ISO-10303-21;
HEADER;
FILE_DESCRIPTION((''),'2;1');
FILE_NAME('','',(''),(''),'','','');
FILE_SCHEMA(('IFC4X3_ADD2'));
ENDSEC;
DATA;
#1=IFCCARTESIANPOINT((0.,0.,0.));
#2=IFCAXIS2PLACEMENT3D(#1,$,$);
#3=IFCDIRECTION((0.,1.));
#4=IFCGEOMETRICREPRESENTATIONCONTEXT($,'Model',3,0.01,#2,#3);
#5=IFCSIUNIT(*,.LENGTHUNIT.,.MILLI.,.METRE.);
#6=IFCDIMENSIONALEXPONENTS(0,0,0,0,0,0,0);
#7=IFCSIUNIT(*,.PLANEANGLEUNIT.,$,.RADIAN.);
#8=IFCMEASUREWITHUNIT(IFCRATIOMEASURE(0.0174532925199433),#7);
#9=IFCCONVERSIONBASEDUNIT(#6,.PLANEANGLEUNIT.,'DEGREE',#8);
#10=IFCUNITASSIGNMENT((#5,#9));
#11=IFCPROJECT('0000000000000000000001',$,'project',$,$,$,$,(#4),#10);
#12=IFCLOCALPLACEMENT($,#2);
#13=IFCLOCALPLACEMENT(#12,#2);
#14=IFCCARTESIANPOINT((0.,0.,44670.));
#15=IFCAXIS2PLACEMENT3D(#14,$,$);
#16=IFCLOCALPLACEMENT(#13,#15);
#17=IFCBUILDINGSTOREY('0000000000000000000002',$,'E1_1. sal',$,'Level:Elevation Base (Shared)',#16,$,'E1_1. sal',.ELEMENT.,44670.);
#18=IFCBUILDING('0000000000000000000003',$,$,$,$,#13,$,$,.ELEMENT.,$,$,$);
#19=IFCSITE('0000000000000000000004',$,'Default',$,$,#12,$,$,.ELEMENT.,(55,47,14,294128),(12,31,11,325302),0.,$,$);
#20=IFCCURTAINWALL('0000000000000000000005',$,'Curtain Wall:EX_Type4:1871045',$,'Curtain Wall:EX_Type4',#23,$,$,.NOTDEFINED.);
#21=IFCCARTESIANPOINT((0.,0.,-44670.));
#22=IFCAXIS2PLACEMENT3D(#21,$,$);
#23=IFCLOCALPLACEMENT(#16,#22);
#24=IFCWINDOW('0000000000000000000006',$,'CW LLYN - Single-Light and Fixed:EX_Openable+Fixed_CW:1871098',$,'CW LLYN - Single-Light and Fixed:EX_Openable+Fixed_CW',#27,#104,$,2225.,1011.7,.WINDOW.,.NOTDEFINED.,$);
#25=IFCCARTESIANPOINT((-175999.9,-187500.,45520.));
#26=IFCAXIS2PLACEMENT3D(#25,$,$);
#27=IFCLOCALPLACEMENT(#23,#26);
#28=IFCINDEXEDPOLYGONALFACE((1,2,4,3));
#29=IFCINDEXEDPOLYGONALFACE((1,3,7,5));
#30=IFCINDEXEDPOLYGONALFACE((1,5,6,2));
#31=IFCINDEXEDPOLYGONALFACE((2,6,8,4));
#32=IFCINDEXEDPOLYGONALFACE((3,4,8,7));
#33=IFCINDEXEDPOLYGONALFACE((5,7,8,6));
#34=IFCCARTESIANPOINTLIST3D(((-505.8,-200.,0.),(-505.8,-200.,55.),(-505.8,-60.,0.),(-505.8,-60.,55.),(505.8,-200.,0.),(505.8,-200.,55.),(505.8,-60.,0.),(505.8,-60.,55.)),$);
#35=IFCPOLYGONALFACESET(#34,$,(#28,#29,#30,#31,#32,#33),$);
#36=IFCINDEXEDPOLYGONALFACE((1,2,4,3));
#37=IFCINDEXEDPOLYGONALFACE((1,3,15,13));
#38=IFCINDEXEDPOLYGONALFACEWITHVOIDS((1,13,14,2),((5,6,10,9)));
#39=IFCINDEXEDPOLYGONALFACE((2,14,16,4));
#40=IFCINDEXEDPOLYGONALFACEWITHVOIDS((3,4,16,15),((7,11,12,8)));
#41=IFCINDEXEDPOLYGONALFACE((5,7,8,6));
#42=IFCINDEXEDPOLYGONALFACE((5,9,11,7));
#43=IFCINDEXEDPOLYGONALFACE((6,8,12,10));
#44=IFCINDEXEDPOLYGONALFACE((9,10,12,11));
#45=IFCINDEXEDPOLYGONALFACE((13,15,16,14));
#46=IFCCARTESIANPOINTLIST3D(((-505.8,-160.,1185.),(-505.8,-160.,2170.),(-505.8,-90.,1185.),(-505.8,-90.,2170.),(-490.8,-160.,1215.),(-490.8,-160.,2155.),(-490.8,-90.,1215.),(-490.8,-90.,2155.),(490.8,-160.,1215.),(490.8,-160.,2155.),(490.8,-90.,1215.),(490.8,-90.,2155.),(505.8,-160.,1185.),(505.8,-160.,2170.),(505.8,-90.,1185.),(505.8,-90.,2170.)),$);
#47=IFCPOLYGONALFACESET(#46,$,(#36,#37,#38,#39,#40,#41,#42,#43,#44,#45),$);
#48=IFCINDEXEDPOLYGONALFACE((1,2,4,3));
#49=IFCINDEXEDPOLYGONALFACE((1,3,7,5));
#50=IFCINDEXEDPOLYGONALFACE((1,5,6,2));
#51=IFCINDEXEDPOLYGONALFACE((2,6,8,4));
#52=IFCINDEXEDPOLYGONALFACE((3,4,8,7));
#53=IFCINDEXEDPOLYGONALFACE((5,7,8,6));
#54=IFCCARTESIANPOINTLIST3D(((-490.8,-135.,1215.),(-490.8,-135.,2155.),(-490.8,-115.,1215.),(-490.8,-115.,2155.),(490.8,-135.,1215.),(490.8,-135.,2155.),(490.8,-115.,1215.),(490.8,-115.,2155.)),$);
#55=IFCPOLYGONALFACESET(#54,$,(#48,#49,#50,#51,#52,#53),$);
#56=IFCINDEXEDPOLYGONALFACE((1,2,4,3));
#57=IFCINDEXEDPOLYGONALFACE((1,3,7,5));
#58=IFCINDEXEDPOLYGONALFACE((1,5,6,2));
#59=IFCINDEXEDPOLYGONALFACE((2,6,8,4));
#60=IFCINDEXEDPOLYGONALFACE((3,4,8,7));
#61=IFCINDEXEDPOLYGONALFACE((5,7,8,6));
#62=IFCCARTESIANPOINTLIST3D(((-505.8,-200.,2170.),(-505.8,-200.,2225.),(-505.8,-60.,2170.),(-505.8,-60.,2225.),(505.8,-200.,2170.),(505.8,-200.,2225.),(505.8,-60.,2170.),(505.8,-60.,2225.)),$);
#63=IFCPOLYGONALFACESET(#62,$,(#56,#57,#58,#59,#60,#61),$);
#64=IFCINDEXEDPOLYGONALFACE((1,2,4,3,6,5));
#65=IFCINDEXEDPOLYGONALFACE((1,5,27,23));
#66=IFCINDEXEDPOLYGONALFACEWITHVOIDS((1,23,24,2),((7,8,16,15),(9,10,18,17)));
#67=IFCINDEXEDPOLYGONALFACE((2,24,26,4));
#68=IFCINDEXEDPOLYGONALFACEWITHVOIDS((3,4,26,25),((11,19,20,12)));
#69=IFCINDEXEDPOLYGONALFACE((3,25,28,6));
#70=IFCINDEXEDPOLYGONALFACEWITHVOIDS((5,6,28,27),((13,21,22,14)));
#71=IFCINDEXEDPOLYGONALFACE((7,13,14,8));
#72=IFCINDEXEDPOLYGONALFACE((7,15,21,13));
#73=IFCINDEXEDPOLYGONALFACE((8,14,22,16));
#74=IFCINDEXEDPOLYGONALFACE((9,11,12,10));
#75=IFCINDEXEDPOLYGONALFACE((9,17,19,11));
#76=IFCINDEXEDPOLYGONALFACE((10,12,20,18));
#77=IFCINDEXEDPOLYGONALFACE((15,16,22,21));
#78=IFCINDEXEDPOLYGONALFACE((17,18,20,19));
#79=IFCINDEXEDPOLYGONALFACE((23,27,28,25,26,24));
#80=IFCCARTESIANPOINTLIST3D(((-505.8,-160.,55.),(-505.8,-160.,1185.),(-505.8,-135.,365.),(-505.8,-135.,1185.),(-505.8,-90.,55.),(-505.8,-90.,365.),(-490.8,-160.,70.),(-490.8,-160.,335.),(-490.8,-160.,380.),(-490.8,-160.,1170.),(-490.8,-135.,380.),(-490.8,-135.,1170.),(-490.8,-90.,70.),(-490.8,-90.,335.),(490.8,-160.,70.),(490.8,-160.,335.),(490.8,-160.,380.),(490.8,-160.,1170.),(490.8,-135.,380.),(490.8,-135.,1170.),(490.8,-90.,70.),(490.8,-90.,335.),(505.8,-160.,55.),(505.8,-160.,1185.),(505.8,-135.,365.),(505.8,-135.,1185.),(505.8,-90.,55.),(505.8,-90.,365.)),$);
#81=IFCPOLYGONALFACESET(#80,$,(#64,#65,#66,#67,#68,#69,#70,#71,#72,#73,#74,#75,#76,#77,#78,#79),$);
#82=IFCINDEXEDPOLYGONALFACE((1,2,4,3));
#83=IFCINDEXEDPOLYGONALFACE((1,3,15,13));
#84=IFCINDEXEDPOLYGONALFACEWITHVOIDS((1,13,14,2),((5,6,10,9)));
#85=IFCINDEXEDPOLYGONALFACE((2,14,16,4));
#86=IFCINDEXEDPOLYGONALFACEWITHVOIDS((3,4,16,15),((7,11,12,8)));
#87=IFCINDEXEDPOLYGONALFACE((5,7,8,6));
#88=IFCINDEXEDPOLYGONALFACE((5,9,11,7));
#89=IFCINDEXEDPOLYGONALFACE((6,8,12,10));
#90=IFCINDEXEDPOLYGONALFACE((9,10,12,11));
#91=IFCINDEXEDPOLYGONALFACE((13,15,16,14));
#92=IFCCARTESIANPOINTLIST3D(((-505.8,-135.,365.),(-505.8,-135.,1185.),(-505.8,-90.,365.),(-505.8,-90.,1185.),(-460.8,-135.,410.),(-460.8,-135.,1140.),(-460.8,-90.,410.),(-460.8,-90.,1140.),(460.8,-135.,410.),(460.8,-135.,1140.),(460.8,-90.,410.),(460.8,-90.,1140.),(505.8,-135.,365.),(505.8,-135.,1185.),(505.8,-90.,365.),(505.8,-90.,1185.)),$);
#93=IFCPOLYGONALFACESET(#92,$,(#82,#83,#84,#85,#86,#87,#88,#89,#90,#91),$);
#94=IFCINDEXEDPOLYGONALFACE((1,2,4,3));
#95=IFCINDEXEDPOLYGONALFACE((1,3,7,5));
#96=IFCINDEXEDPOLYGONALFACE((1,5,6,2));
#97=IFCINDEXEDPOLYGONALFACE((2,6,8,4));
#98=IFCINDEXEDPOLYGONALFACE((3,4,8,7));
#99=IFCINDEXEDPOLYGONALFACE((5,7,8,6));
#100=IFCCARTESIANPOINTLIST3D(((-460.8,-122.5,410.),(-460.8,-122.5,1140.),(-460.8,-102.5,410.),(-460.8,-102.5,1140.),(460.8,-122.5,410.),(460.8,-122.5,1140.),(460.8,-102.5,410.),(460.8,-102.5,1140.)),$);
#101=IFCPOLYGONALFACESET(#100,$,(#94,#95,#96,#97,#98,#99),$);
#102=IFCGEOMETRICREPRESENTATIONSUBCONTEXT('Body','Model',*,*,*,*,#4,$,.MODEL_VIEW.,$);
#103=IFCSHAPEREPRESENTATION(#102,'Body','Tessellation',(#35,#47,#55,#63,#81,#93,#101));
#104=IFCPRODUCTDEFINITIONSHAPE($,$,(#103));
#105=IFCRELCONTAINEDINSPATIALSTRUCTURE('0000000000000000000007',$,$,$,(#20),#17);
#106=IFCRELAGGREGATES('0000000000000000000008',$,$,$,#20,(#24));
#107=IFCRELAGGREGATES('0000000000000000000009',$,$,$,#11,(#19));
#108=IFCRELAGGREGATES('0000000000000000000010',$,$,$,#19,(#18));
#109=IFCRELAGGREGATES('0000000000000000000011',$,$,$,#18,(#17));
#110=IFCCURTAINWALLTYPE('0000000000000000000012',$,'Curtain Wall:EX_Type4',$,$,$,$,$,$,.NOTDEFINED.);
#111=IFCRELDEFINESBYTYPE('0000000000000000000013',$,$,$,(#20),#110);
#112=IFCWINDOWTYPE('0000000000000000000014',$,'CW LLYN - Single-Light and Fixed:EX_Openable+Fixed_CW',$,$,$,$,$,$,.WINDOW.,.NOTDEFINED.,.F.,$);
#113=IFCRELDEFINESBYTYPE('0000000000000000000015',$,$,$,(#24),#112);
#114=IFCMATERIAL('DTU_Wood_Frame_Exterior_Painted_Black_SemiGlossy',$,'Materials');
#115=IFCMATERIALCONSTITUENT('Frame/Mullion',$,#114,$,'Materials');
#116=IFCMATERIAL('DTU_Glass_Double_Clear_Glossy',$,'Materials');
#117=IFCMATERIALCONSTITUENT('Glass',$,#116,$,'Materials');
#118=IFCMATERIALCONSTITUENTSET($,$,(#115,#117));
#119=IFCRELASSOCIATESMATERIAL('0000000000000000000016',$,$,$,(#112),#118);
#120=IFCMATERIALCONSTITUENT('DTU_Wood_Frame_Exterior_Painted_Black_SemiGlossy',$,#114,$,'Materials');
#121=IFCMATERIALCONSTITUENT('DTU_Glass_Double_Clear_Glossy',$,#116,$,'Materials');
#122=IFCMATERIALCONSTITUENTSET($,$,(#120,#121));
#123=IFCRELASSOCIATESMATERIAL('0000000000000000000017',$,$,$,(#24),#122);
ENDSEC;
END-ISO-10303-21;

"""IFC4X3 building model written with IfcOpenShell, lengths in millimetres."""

from ifc_helpers import new_model, entity, si_unit, converted_unit, direction, frame, frame_2d, origin, origin_2d_with_axis, place, context, subcontext, project, spatial, polyline, rectangle, outline, extrude, source, transform, mapped, material, constituent, constituent_set, type_object, type_shapes, element, aggregate, save


model = new_model("IFC4X3")

# Units and contexts
model_context = context("Model", 3, precision=0.01, world=origin(), true_north=direction((0.0, 1.0)))
body_context = subcontext(model_context, "Body", "Model", "MODEL_VIEW")
ifc_project = project(units=[si_unit("LENGTHUNIT", "METRE", prefix="MILLI"), converted_unit("PLANEANGLEUNIT", "DEGREE", entity("IfcRatioMeasure", 0.0174532925199433), si_unit("PLANEANGLEUNIT", "RADIAN"), dimensions=[0, 0, 0, 0, 0, 0, 0])], contexts=[model_context])

# Site, building, storey
site_placement = place(None, origin())
site = spatial("IfcSite", under=ifc_project, at=site_placement, Name="Default", CompositionType="ELEMENT", RefLatitude=(55, 47, 14, 294128), RefLongitude=(12, 31, 11, 325302), RefElevation=0.0)
building_placement = place(site_placement, origin())
building = spatial("IfcBuilding", under=site, at=building_placement, CompositionType="ELEMENT")
storey_placement = place(building_placement, frame((0.0, 0.0, 44670.0)))
storey = spatial("IfcBuildingStorey", under=building, at=storey_placement, Name="E1_1. sal", ObjectType="Level:Elevation Base (Shared)", LongName="E1_1. sal", CompositionType="ELEMENT", Elevation=44670.0)

# Curtain wall
curtain_wall_type_1 = type_object("IfcCurtainWallType", Name="Curtain Wall:EX_Type4", PredefinedType="NOTDEFINED")
curtain_wall_1_placement = place(storey_placement, frame((0.0, 0.0, -44670.0)))
curtain_wall_1 = element("IfcCurtainWall", 1, at=curtain_wall_1_placement, inside=storey, type_object=curtain_wall_type_1, Name="Curtain Wall:EX_Type4:1871045", ObjectType="Curtain Wall:EX_Type4", PredefinedType="NOTDEFINED")

# Shared definitions
ifc_material_1 = material(Name="DTU_Wood_Frame_Exterior_Painted_Black_SemiGlossy", Category="Materials")
ifc_material_2 = material(Name="DTU_Glass_Double_Clear_Glossy", Category="Materials")

# Window, openings
ifc_constituent_1 = constituent(ifc_material_1, Name="DTU_Wood_Frame_Exterior_Painted_Black_SemiGlossy", Category="Materials")
ifc_constituent_2 = constituent(ifc_material_2, Name="DTU_Glass_Double_Clear_Glossy", Category="Materials")
ifc_constituent_set_1 = constituent_set(constituents=[ifc_constituent_1, ifc_constituent_2])
ifc_constituent_3 = constituent(ifc_material_1, Name="Frame/Mullion", Category="Materials")
ifc_constituent_4 = constituent(ifc_material_2, Name="Glass", Category="Materials")
ifc_constituent_set_2 = constituent_set(constituents=[ifc_constituent_3, ifc_constituent_4])
window_type_1 = type_object("IfcWindowType", Name="CW LLYN - Single-Light and Fixed:EX_Openable+Fixed_CW", ParameterTakesPrecedence=False, PartitioningType="NOTDEFINED", PredefinedType="WINDOW", material=ifc_constituent_set_2)
shared_shape_1 = source(origin(), body_context, "Body", "SweptSolid", [
    extrude(rectangle(XDim=140.0, YDim=1011.7, at=origin_2d_with_axis()), frame((0.0, -130.0, 0.0), z_axis=(0.0, 0.0, 1.0), x_axis=(0.0, -1.0, 0.0)), (0.0, 0.0, 1.0), 55.0),
    extrude(outline(polyline([(-492.5, -505.8), (492.5, -505.8), (492.5, 505.8), (-492.5, 505.8), (-492.5, -505.8)]), holes=[polyline([(477.5, -490.8), (-462.5, -490.8), (-462.5, 490.8), (477.5, 490.8), (477.5, -490.8)])]), frame((0.0, -90.0, 1677.5), z_axis=(0.0, -1.0, 0.0), x_axis=(0.0, 0.0, 1.0)), (0.0, 0.0, 1.0), 70.0),
    extrude(rectangle(XDim=981.7, YDim=20.0, at=frame_2d((0.0, 0.0), x_axis=(1.0, 0.0))), frame((0.0, -125.0, 1215.0), z_axis=(0.0, 0.0, 1.0), x_axis=(-1.0, 0.0, 0.0)), (0.0, 0.0, 1.0), 940.0),
    extrude(rectangle(XDim=981.7, YDim=20.0, at=frame_2d((0.0, 0.0), x_axis=(1.0, 0.0))), frame((0.0, -125.0, 70.0), z_axis=(0.0, 0.0, 1.0), x_axis=(-1.0, 0.0, 0.0)), (0.0, 0.0, 1.0), 265.0),
    extrude(rectangle(XDim=140.0, YDim=1011.7, at=frame_2d((0.0, 0.0), x_axis=(1.0, 0.0))), frame((0.0, -130.0, 2170.0), z_axis=(0.0, 0.0, 1.0), x_axis=(0.0, -1.0, 0.0)), (0.0, 0.0, 1.0), 55.0),
    extrude(outline(polyline([(-38.3, -480.0), (31.7, -480.0), (31.7, 650.0), (6.7, 650.0), (6.7, -170.0), (-38.3, -170.0), (-38.3, -480.0)])), frame((505.8, -128.3, 535.0), z_axis=(-1.0, 0.0, 0.0), x_axis=(0.0, -1.0, 0.0)), (0.0, 0.0, 1.0), 1011.7),
    extrude(outline(polyline([(-410.0, -505.8), (410.0, -505.8), (410.0, 505.8), (-410.0, 505.8), (-410.0, -505.8)]), holes=[polyline([(-365.0, 460.8), (365.0, 460.8), (365.0, -460.8), (-365.0, -460.8), (-365.0, 460.8)])]), frame((0.0, -90.0, 775.0), z_axis=(0.0, -1.0, 0.0), x_axis=(0.0, 0.0, 1.0)), (0.0, 0.0, 1.0), 45.0),
    extrude(rectangle(XDim=921.7, YDim=20.0, at=frame_2d((0.0, 0.0), x_axis=(1.0, 0.0))), frame((0.0, -112.5, 410.0), z_axis=(0.0, 0.0, 1.0), x_axis=(-1.0, 0.0, 0.0)), (0.0, 0.0, 1.0), 730.0),
])
type_shapes(window_type_1, [shared_shape_1])
window_1_placement = place(curtain_wall_1_placement, frame((-175999.9, -187500.0, 45520.0)))
window_1 = element("IfcWindow", 2, at=window_1_placement, type_object=window_type_1, material=ifc_constituent_set_1, Name="CW LLYN - Single-Light and Fixed:EX_Openable+Fixed_CW:1871098", ObjectType="CW LLYN - Single-Light and Fixed:EX_Openable+Fixed_CW", OverallHeight=2225.0, OverallWidth=1011.7, PartitioningType="NOTDEFINED", PredefinedType="WINDOW", context=body_context, shape_type="MappedRepresentation", body=[
    mapped(shared_shape_1, transform((0.0, 0.0, 0.0), scale=1.0)),
])
opening_1_placement = place(curtain_wall_1_placement, frame((-175999.9, -187500.0, 90190.0), z_axis=(0.0, 0.0, 1.0), x_axis=(-1.0, 0.0, 0.0)))
opening_1 = element("IfcOpeningElement", 3, at=opening_1_placement, cuts=window_1, PredefinedType="OPENING", context=body_context, shape_type="SweptSolid", body=[
    extrude(rectangle(XDim=265.0, YDim=981.7, at=frame_2d((0.0, 0.0), x_axis=(1.0, 0.0))), frame((0.0, 160.0, -44467.5), z_axis=(0.0, -1.0, 0.0), x_axis=(0.0, 0.0, 1.0)), (0.0, 0.0, 1.0), 70.0),
])
opening_2_placement = place(curtain_wall_1_placement, frame((-175999.9, -187500.0, 90190.0), z_axis=(0.0, 0.0, 1.0), x_axis=(-1.0, 0.0, 0.0)))
opening_2 = element("IfcOpeningElement", 4, at=opening_2_placement, cuts=window_1, PredefinedType="OPENING", context=body_context, shape_type="SweptSolid", body=[
    extrude(rectangle(XDim=790.0, YDim=981.7, at=frame_2d((0.0, 0.0), x_axis=(1.0, 0.0))), frame((0.0, 135.0, -43895.0), z_axis=(0.0, 1.0, 0.0), x_axis=(0.0, 0.0, 1.0)), (0.0, 0.0, 1.0), 25.0),
])

aggregate(curtain_wall_1, [window_1, opening_1, opening_2])

save(model, "model.ifc")
